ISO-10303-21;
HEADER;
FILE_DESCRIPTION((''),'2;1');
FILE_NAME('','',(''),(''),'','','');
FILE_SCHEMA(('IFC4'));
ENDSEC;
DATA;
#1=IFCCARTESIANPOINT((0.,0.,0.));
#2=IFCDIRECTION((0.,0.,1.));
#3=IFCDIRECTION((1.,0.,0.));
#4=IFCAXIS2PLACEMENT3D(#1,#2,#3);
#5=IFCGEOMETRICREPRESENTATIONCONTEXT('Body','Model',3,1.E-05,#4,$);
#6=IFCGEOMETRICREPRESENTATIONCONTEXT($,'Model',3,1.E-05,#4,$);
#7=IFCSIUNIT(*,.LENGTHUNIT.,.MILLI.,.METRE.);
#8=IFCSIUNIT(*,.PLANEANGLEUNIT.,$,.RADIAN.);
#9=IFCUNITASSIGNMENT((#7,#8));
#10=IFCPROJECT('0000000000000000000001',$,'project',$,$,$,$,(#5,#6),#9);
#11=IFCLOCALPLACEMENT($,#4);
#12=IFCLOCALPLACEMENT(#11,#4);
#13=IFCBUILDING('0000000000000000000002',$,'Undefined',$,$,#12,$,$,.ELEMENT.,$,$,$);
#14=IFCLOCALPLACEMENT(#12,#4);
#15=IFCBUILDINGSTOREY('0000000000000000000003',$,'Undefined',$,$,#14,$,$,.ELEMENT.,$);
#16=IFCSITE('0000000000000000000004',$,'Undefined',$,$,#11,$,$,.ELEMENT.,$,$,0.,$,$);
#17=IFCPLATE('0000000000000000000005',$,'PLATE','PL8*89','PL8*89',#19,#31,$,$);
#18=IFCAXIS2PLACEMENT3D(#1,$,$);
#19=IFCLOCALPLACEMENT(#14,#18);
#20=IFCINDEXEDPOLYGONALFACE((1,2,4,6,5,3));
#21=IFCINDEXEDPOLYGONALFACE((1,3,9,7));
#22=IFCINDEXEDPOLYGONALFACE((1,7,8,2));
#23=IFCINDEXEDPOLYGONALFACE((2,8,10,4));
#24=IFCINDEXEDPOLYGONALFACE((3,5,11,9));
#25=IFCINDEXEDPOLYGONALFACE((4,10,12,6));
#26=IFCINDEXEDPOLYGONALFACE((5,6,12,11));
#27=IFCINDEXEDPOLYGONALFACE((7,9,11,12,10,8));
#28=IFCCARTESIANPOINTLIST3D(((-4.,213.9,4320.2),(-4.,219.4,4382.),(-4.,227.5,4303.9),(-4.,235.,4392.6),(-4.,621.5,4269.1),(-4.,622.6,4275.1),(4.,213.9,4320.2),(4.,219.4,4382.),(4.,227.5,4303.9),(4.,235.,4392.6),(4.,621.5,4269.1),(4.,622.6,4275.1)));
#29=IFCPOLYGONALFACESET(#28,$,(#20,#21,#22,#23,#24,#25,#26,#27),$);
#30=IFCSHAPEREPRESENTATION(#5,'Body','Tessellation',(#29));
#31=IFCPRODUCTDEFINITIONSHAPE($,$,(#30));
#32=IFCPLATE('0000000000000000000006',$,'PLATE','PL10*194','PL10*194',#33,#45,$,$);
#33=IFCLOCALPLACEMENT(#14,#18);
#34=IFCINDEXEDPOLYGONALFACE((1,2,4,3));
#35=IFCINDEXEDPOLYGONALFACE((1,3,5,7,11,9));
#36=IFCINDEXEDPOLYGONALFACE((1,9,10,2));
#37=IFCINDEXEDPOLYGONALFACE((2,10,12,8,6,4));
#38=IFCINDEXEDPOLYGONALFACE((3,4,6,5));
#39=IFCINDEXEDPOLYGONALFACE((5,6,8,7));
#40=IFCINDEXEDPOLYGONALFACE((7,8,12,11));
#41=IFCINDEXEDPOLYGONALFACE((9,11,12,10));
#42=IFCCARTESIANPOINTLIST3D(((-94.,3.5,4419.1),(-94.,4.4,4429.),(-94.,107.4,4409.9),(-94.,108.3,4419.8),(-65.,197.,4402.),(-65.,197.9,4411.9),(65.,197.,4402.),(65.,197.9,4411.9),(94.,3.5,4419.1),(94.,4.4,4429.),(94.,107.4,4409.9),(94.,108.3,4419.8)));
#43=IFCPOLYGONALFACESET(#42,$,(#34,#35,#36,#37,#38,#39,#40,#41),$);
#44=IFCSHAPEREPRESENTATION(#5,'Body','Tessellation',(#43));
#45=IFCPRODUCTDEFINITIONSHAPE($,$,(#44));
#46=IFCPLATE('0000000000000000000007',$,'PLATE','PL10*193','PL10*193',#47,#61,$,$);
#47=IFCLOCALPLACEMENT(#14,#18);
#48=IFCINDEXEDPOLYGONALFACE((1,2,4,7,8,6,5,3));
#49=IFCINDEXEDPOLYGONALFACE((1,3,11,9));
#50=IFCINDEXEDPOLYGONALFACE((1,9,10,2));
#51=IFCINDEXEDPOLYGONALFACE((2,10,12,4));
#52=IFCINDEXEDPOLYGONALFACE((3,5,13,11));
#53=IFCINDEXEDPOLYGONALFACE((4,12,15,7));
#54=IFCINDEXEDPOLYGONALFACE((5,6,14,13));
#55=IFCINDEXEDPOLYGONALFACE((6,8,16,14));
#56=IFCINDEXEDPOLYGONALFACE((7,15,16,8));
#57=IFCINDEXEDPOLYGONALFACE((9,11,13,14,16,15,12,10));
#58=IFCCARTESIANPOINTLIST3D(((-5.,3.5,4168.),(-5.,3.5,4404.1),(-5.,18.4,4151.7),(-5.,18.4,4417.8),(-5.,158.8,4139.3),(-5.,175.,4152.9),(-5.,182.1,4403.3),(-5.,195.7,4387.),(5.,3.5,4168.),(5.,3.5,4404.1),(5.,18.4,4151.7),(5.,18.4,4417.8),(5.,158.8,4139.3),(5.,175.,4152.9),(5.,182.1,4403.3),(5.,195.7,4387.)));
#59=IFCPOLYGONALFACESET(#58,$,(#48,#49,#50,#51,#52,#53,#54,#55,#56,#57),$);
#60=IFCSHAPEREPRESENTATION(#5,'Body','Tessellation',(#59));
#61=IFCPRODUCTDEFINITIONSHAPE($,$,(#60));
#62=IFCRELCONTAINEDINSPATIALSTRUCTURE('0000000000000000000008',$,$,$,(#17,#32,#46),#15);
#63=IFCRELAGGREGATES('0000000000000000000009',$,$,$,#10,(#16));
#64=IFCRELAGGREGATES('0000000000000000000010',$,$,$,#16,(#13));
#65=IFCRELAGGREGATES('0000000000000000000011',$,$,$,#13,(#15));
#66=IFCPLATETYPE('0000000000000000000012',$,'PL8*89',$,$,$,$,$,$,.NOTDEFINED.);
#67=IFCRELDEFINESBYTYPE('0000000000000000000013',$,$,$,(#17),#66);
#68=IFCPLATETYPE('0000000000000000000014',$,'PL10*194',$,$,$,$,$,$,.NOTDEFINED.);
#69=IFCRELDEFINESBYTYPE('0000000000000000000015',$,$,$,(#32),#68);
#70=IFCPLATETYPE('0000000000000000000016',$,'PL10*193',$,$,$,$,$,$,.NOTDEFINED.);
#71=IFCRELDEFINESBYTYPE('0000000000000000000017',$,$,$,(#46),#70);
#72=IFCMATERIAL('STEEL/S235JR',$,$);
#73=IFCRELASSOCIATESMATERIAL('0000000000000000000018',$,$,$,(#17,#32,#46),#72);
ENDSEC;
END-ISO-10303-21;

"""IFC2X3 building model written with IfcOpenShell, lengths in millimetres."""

from ifc_helpers import new_model, si_unit, frame, origin_with_axes, place, context, project, spatial, polyline, outline, extrude, material, type_object, element, save


model = new_model("IFC2X3")

# Units and contexts
model_context_1 = context("Model", 3, precision=1e-05, world=origin_with_axes(), identifier="Body")
model_context_2 = context("Model", 3, precision=1e-05, world=origin_with_axes())
ifc_project = project(units=[si_unit("LENGTHUNIT", "METRE", prefix="MILLI"), si_unit("PLANEANGLEUNIT", "RADIAN")], contexts=[model_context_1, model_context_2])

# Site, building, storey
site_placement = place(None, origin_with_axes())
site = spatial("IfcSite", under=ifc_project, at=site_placement, Name="Undefined", CompositionType="ELEMENT", RefElevation=0.0)
building_placement = place(site_placement, origin_with_axes())
building = spatial("IfcBuilding", under=site, at=building_placement, Name="Undefined", CompositionType="ELEMENT")
storey_placement = place(building_placement, origin_with_axes())
storey = spatial("IfcBuildingStorey", under=building, at=storey_placement, Name="Undefined", CompositionType="ELEMENT")

# Shared definitions
ifc_material = material(Name="STEEL/S235JR")

# Plates
plate_type_1 = type_object("IfcPlateType", Name="PL8*89", PredefinedType="NOTDEFINED")
plate_1_placement = place(storey_placement, frame((0.0, 212.6, 4305.2), z_axis=(-1.0, 0.0, 0.0), x_axis=(0.0, 0.08801, 0.99612)))
element("IfcPlate", 1, at=plate_1_placement, inside=storey, type_object=plate_type_1, material=ifc_material, Name="PLATE", Description="PL8*89", ObjectType="PL8*89", context=model_context_1, shape_type="SweptSolid", body=[
    extrude(outline(polyline([(0.0, 15.0), (15.0, 0.0), (77.1, 0.0), (89.0, 14.7), (6.1, 411.1), (0.0, 410.5), (0.0, 15.0)])), frame((0.0, 0.0, -4.0), z_axis=(0.0, 0.0, 1.0), x_axis=(1.0, 0.0, 0.0)), (0.0, 0.0, 1.0), 8.0),
])
plate_type_2 = type_object("IfcPlateType", Name="PL10*194", PredefinedType="NOTDEFINED")
plate_2_placement = place(storey_placement, frame((-65.0, 197.5, 4406.9), z_axis=(0.0, 0.08801, 0.99612), x_axis=(-0.306693, -0.948115, 0.083768)))
element("IfcPlate", 2, at=plate_2_placement, inside=storey, type_object=plate_type_2, material=ifc_material, Name="PLATE", Description="PL10*194", ObjectType="PL10*194", context=model_context_1, shape_type="SweptSolid", body=[
    extrude(outline(polyline([(0.0, 0.0), (94.6, 0.0), (193.8, 32.0), (136.2, 210.9), (36.9, 178.9), (-39.9, 123.7), (0.0, 0.0)])), frame((0.0, 0.0, -5.0), z_axis=(0.0, 0.0, 1.0), x_axis=(1.0, 0.0, 0.0)), (0.0, 0.0, 1.0), 10.0),
])
plate_type_3 = type_object("IfcPlateType", Name="PL10*193", PredefinedType="NOTDEFINED")
plate_3_placement = place(storey_placement, frame((0.0, 3.5, 4419.1), z_axis=(-1.0, 0.0, 0.0), x_axis=(0.0, 0.996098, -0.088258)))
element("IfcPlate", 3, at=plate_3_placement, inside=storey, type_object=plate_type_3, material=ifc_material, Name="PLATE", Description="PL10*193", ObjectType="PL10*193", context=model_context_1, shape_type="SweptSolid", body=[
    extrude(outline(polyline([(1.3, 14.9), (15.0, 0.0), (179.3, 0.0), (194.3, 15.0), (194.4, 250.0), (179.4, 265.0), (38.5, 265.0), (22.2, 250.1), (1.3, 14.9)])), frame((0.0, 0.0, -5.0), z_axis=(0.0, 0.0, 1.0), x_axis=(1.0, 0.0, 0.0)), (0.0, 0.0, 1.0), 10.0),
])

save(model, "model.ifc")
